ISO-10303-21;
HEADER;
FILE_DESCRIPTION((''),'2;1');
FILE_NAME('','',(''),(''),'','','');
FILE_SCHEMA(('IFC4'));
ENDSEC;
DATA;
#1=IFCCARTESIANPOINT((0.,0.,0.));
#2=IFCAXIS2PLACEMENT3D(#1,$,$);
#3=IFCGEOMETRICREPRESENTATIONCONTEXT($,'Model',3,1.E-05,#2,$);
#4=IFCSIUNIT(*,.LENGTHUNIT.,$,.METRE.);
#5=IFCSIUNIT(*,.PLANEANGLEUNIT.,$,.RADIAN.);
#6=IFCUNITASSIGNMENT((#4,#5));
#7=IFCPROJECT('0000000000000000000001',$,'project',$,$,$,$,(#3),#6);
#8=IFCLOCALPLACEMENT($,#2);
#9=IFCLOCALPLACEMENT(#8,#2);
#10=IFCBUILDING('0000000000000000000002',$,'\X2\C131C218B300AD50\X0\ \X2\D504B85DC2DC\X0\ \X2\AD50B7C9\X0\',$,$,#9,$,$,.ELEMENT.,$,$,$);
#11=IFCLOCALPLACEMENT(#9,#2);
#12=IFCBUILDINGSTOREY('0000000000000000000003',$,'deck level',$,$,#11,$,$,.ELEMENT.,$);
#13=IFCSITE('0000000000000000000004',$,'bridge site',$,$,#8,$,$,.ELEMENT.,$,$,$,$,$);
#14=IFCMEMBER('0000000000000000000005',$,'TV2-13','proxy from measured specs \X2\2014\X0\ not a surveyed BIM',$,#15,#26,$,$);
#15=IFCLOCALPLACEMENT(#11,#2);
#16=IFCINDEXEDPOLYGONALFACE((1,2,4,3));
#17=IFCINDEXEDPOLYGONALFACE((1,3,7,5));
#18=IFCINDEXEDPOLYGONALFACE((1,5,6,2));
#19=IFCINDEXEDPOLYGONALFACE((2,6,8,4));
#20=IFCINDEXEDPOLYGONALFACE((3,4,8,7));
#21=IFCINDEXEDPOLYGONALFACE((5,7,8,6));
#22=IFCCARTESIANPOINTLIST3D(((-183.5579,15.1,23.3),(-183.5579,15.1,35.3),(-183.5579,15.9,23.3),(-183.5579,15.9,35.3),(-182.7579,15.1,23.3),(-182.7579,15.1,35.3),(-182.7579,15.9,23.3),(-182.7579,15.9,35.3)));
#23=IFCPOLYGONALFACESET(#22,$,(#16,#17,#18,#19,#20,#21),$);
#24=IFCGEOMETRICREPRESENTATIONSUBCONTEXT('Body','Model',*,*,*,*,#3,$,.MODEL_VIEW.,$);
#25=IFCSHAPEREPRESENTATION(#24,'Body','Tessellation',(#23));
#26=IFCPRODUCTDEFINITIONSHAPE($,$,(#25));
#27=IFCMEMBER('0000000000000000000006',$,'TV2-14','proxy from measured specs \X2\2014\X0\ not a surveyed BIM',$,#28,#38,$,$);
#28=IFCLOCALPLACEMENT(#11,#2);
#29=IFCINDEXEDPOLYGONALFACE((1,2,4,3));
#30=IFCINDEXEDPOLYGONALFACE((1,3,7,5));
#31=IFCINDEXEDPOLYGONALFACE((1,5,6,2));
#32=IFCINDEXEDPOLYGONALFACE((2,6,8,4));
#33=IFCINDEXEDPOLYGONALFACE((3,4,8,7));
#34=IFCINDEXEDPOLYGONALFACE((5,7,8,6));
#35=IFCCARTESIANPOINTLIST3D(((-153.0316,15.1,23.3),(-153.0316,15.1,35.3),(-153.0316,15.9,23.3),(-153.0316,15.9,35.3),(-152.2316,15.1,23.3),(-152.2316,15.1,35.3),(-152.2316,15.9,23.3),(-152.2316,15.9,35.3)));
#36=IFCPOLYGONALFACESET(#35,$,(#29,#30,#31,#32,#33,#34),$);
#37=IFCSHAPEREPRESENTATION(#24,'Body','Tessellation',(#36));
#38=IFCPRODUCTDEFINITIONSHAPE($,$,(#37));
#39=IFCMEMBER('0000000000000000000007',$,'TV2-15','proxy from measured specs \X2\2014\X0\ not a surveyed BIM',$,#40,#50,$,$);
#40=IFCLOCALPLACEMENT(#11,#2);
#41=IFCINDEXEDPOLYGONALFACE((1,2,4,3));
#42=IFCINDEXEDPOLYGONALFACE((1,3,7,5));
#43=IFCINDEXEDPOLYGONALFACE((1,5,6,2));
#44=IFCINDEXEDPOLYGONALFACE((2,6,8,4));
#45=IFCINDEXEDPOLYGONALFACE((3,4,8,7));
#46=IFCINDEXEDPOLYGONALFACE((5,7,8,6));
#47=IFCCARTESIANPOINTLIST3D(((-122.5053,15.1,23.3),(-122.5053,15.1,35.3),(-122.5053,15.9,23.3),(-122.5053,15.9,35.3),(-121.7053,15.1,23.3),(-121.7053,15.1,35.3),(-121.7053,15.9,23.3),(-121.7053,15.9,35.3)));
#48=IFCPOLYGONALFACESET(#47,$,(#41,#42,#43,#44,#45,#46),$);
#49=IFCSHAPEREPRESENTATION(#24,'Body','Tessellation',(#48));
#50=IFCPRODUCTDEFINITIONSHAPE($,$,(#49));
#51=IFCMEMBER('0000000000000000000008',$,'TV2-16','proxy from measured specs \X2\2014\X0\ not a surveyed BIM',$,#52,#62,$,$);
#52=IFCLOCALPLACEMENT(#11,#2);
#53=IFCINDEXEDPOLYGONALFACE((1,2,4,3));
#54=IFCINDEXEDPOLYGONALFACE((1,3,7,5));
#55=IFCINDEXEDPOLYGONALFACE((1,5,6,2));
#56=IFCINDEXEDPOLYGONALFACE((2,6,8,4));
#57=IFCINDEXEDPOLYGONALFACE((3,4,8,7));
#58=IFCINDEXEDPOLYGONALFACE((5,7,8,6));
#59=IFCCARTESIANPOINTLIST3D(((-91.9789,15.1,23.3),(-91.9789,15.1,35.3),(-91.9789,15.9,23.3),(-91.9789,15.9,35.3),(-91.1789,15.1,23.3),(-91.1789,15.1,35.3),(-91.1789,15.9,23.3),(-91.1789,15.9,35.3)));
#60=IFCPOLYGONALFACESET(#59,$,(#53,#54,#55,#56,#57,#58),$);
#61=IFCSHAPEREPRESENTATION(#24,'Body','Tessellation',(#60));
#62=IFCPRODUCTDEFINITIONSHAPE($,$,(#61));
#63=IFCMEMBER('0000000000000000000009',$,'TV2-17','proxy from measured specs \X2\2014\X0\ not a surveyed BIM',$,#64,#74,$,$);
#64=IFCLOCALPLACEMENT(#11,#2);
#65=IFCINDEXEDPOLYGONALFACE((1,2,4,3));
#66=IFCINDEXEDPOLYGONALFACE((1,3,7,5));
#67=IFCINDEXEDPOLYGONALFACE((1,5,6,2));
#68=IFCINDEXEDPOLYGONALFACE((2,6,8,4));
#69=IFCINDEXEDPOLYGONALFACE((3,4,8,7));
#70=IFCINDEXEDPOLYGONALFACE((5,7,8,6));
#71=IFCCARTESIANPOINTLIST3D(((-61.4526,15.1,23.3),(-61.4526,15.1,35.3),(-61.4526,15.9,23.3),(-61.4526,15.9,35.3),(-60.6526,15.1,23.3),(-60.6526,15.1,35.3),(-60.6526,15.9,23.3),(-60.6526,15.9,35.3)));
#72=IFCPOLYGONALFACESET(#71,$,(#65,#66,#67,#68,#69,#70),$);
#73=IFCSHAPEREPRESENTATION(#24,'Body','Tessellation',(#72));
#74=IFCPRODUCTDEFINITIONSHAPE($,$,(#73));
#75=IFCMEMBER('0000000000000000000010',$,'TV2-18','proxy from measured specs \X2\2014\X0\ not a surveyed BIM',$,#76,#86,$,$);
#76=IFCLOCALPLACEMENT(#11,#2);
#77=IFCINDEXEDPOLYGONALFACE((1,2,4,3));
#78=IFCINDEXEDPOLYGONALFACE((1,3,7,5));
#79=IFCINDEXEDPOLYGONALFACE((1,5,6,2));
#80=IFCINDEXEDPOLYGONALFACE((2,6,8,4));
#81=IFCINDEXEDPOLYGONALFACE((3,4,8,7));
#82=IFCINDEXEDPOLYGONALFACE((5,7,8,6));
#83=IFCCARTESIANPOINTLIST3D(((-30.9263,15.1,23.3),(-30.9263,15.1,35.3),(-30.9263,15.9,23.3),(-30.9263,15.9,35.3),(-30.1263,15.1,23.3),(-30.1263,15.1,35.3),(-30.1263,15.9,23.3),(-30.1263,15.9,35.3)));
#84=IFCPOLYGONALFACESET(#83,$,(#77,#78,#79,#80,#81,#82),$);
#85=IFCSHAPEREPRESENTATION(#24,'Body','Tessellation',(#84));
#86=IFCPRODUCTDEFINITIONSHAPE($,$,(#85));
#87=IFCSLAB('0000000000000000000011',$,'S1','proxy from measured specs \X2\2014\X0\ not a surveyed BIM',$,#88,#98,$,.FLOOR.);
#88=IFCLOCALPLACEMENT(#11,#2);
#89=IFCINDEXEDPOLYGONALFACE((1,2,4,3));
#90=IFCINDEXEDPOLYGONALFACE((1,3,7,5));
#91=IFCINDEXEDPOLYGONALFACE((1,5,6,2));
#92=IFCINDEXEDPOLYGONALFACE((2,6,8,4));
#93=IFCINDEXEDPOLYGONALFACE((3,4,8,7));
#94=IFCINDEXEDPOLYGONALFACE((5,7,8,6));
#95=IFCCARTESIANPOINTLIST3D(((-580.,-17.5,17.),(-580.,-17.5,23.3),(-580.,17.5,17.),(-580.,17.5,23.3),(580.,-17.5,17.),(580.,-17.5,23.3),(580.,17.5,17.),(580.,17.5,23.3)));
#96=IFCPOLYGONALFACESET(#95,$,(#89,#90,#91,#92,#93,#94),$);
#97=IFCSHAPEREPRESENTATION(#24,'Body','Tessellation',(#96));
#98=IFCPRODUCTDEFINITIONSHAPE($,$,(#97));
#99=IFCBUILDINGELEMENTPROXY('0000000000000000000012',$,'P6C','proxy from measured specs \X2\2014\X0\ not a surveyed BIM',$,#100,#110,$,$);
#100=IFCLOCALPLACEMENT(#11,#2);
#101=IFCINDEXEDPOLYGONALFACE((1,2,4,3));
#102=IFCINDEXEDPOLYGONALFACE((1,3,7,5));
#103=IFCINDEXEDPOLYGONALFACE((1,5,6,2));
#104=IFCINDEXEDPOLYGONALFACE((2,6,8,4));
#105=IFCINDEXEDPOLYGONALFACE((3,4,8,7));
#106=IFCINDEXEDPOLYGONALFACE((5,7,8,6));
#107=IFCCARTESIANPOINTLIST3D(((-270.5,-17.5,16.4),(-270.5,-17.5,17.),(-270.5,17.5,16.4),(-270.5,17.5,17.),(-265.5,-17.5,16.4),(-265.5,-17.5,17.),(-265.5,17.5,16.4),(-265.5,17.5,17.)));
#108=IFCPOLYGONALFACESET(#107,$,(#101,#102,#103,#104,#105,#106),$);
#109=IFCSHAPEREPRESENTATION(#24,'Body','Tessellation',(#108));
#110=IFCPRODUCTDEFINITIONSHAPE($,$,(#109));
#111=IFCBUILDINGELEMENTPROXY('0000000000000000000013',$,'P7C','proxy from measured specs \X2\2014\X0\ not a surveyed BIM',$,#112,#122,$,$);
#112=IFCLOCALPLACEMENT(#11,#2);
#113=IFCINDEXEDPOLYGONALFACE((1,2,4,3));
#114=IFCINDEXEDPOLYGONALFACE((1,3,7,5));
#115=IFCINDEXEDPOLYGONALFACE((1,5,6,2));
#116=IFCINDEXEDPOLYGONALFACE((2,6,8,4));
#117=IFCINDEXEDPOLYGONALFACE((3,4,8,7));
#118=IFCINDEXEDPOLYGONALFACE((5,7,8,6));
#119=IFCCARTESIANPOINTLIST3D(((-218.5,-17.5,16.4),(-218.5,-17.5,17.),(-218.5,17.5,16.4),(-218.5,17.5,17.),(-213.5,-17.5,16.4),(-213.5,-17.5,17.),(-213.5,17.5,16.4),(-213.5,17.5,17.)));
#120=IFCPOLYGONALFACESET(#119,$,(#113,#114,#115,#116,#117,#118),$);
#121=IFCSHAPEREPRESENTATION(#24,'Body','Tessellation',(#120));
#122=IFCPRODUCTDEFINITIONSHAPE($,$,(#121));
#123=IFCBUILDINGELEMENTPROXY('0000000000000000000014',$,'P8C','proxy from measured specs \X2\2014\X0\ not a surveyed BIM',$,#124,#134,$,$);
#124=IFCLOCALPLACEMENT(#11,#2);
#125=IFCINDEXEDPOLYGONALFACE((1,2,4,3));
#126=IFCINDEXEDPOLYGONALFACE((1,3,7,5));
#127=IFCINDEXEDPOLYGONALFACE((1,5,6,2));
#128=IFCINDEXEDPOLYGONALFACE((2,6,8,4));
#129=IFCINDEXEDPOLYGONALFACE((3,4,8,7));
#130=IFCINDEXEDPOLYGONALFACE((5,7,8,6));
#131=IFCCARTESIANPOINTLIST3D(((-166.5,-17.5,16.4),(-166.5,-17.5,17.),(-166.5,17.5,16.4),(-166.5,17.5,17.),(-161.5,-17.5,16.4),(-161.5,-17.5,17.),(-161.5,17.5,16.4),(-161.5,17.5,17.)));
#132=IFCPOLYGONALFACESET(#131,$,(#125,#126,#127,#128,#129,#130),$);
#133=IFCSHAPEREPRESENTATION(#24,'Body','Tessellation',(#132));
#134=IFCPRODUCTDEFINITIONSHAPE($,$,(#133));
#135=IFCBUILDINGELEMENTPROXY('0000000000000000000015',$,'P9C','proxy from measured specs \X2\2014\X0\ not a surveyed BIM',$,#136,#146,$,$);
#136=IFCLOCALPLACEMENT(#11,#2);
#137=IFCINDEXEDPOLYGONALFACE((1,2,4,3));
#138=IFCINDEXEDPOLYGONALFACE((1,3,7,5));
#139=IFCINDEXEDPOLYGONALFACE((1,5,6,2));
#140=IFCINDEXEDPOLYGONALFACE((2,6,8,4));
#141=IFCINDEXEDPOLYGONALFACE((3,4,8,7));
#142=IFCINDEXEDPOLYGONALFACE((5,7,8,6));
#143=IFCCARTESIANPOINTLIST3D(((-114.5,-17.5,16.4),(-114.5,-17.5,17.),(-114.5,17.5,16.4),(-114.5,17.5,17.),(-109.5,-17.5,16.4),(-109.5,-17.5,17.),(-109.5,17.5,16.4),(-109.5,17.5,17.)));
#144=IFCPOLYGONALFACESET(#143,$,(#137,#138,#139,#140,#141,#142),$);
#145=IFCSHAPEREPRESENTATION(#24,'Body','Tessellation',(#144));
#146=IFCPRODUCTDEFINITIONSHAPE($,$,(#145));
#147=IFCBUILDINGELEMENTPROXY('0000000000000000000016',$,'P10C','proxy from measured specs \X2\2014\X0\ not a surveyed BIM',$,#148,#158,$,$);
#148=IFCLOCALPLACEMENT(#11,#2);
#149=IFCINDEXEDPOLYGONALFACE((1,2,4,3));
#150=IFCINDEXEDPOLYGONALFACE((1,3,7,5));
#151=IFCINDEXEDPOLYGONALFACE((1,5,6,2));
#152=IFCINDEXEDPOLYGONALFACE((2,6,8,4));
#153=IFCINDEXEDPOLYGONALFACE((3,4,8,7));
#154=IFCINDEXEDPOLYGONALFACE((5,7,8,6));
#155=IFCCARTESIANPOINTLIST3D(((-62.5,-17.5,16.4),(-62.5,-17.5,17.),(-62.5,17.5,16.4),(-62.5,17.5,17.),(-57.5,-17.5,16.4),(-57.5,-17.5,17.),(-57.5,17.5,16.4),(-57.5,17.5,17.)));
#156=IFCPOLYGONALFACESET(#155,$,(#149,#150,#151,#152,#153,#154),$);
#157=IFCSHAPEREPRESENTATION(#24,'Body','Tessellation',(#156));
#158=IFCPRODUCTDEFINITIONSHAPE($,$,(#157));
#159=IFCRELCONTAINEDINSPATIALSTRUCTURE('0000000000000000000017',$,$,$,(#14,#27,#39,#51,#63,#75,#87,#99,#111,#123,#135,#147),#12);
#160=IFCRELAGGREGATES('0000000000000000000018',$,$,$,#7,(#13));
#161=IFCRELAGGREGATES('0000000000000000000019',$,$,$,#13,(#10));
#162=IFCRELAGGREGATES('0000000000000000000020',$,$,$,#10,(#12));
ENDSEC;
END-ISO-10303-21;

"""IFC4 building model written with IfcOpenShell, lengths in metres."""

from ifc_helpers import new_model, si_unit, frame, origin, origin_2d, place, context, subcontext, project, spatial, rectangle, extrude, element, save


model = new_model("IFC4")

# Units and contexts
model_context = context("Model", 3, precision=1e-05, world=origin())
body_context = subcontext(model_context, "Body", "Model", "MODEL_VIEW")
ifc_project = project(units=[si_unit("LENGTHUNIT", "METRE"), si_unit("PLANEANGLEUNIT", "RADIAN")], contexts=[model_context])

# Site, building, storey
site_placement = place(None, origin())
site = spatial("IfcSite", under=ifc_project, at=site_placement, Name="bridge site", CompositionType="ELEMENT")
building_placement = place(site_placement, origin())
building = spatial("IfcBuilding", under=site, at=building_placement, Name="성수대교 프록시 교량", CompositionType="ELEMENT")
storey_placement = place(building_placement, origin())
storey = spatial("IfcBuildingStorey", under=building, at=storey_placement, Name="deck level", CompositionType="ELEMENT")

# Members
for number, where, name in (
    (1, (-183.1579, 15.5, 23.3), "TV2-13"),
    (2, (-152.6316, 15.5, 23.3), "TV2-14"),
    (3, (-122.1053, 15.5, 23.3), "TV2-15"),
    (4, (-91.5789, 15.5, 23.3), "TV2-16"),
):
    element("IfcMember", number, at=place(storey_placement, frame(where)), inside=storey, Name=name, Description="proxy from measured specs — not a surveyed BIM", context=body_context, shape_type="SweptSolid", body=[
        extrude(rectangle(XDim=0.8, YDim=0.8, at=origin_2d()), origin(), (0.0, 0.0, 1.0), 12.0),
    ])
for number, where, name in (
    (5, (-61.0526, 15.5, 23.3), "TV2-17"),
    (6, (-30.5263, 15.5, 23.3), "TV2-18"),
):
    element("IfcMember", number, at=place(storey_placement, frame(where)), inside=storey, Name=name, Description="proxy from measured specs — not a surveyed BIM", context=body_context, shape_type="SweptSolid", body=[
        extrude(rectangle(XDim=0.8, YDim=0.8, at=origin_2d()), origin(), (0.0, 0.0, 1.0), 12.0),
    ])

# Slab
slab_placement = place(storey_placement, frame((0.0, 0.0, 17.0)))
element("IfcSlab", 7, at=slab_placement, inside=storey, Name="S1", Description="proxy from measured specs — not a surveyed BIM", PredefinedType="FLOOR", context=body_context, shape_type="SweptSolid", body=[
    extrude(rectangle(XDim=1160.0, YDim=35.0, at=origin_2d()), origin(), (0.0, 0.0, 1.0), 6.3),
])

# Building element proxies
for number, where, name in (
    (8, (-268.0, 0.0, 16.4), "P6C"),
    (9, (-216.0, 0.0, 16.4), "P7C"),
    (10, (-164.0, 0.0, 16.4), "P8C"),
    (11, (-112.0, 0.0, 16.4), "P9C"),
    (12, (-60.0, 0.0, 16.4), "P10C"),
):
    element("IfcBuildingElementProxy", number, at=place(storey_placement, frame(where)), inside=storey, Name=name, Description="proxy from measured specs — not a surveyed BIM", context=body_context, shape_type="SweptSolid", body=[
        extrude(rectangle(XDim=5.0, YDim=35.0, at=origin_2d()), origin(), (0.0, 0.0, 1.0), 0.6),
    ])

save(model, "model.ifc")
